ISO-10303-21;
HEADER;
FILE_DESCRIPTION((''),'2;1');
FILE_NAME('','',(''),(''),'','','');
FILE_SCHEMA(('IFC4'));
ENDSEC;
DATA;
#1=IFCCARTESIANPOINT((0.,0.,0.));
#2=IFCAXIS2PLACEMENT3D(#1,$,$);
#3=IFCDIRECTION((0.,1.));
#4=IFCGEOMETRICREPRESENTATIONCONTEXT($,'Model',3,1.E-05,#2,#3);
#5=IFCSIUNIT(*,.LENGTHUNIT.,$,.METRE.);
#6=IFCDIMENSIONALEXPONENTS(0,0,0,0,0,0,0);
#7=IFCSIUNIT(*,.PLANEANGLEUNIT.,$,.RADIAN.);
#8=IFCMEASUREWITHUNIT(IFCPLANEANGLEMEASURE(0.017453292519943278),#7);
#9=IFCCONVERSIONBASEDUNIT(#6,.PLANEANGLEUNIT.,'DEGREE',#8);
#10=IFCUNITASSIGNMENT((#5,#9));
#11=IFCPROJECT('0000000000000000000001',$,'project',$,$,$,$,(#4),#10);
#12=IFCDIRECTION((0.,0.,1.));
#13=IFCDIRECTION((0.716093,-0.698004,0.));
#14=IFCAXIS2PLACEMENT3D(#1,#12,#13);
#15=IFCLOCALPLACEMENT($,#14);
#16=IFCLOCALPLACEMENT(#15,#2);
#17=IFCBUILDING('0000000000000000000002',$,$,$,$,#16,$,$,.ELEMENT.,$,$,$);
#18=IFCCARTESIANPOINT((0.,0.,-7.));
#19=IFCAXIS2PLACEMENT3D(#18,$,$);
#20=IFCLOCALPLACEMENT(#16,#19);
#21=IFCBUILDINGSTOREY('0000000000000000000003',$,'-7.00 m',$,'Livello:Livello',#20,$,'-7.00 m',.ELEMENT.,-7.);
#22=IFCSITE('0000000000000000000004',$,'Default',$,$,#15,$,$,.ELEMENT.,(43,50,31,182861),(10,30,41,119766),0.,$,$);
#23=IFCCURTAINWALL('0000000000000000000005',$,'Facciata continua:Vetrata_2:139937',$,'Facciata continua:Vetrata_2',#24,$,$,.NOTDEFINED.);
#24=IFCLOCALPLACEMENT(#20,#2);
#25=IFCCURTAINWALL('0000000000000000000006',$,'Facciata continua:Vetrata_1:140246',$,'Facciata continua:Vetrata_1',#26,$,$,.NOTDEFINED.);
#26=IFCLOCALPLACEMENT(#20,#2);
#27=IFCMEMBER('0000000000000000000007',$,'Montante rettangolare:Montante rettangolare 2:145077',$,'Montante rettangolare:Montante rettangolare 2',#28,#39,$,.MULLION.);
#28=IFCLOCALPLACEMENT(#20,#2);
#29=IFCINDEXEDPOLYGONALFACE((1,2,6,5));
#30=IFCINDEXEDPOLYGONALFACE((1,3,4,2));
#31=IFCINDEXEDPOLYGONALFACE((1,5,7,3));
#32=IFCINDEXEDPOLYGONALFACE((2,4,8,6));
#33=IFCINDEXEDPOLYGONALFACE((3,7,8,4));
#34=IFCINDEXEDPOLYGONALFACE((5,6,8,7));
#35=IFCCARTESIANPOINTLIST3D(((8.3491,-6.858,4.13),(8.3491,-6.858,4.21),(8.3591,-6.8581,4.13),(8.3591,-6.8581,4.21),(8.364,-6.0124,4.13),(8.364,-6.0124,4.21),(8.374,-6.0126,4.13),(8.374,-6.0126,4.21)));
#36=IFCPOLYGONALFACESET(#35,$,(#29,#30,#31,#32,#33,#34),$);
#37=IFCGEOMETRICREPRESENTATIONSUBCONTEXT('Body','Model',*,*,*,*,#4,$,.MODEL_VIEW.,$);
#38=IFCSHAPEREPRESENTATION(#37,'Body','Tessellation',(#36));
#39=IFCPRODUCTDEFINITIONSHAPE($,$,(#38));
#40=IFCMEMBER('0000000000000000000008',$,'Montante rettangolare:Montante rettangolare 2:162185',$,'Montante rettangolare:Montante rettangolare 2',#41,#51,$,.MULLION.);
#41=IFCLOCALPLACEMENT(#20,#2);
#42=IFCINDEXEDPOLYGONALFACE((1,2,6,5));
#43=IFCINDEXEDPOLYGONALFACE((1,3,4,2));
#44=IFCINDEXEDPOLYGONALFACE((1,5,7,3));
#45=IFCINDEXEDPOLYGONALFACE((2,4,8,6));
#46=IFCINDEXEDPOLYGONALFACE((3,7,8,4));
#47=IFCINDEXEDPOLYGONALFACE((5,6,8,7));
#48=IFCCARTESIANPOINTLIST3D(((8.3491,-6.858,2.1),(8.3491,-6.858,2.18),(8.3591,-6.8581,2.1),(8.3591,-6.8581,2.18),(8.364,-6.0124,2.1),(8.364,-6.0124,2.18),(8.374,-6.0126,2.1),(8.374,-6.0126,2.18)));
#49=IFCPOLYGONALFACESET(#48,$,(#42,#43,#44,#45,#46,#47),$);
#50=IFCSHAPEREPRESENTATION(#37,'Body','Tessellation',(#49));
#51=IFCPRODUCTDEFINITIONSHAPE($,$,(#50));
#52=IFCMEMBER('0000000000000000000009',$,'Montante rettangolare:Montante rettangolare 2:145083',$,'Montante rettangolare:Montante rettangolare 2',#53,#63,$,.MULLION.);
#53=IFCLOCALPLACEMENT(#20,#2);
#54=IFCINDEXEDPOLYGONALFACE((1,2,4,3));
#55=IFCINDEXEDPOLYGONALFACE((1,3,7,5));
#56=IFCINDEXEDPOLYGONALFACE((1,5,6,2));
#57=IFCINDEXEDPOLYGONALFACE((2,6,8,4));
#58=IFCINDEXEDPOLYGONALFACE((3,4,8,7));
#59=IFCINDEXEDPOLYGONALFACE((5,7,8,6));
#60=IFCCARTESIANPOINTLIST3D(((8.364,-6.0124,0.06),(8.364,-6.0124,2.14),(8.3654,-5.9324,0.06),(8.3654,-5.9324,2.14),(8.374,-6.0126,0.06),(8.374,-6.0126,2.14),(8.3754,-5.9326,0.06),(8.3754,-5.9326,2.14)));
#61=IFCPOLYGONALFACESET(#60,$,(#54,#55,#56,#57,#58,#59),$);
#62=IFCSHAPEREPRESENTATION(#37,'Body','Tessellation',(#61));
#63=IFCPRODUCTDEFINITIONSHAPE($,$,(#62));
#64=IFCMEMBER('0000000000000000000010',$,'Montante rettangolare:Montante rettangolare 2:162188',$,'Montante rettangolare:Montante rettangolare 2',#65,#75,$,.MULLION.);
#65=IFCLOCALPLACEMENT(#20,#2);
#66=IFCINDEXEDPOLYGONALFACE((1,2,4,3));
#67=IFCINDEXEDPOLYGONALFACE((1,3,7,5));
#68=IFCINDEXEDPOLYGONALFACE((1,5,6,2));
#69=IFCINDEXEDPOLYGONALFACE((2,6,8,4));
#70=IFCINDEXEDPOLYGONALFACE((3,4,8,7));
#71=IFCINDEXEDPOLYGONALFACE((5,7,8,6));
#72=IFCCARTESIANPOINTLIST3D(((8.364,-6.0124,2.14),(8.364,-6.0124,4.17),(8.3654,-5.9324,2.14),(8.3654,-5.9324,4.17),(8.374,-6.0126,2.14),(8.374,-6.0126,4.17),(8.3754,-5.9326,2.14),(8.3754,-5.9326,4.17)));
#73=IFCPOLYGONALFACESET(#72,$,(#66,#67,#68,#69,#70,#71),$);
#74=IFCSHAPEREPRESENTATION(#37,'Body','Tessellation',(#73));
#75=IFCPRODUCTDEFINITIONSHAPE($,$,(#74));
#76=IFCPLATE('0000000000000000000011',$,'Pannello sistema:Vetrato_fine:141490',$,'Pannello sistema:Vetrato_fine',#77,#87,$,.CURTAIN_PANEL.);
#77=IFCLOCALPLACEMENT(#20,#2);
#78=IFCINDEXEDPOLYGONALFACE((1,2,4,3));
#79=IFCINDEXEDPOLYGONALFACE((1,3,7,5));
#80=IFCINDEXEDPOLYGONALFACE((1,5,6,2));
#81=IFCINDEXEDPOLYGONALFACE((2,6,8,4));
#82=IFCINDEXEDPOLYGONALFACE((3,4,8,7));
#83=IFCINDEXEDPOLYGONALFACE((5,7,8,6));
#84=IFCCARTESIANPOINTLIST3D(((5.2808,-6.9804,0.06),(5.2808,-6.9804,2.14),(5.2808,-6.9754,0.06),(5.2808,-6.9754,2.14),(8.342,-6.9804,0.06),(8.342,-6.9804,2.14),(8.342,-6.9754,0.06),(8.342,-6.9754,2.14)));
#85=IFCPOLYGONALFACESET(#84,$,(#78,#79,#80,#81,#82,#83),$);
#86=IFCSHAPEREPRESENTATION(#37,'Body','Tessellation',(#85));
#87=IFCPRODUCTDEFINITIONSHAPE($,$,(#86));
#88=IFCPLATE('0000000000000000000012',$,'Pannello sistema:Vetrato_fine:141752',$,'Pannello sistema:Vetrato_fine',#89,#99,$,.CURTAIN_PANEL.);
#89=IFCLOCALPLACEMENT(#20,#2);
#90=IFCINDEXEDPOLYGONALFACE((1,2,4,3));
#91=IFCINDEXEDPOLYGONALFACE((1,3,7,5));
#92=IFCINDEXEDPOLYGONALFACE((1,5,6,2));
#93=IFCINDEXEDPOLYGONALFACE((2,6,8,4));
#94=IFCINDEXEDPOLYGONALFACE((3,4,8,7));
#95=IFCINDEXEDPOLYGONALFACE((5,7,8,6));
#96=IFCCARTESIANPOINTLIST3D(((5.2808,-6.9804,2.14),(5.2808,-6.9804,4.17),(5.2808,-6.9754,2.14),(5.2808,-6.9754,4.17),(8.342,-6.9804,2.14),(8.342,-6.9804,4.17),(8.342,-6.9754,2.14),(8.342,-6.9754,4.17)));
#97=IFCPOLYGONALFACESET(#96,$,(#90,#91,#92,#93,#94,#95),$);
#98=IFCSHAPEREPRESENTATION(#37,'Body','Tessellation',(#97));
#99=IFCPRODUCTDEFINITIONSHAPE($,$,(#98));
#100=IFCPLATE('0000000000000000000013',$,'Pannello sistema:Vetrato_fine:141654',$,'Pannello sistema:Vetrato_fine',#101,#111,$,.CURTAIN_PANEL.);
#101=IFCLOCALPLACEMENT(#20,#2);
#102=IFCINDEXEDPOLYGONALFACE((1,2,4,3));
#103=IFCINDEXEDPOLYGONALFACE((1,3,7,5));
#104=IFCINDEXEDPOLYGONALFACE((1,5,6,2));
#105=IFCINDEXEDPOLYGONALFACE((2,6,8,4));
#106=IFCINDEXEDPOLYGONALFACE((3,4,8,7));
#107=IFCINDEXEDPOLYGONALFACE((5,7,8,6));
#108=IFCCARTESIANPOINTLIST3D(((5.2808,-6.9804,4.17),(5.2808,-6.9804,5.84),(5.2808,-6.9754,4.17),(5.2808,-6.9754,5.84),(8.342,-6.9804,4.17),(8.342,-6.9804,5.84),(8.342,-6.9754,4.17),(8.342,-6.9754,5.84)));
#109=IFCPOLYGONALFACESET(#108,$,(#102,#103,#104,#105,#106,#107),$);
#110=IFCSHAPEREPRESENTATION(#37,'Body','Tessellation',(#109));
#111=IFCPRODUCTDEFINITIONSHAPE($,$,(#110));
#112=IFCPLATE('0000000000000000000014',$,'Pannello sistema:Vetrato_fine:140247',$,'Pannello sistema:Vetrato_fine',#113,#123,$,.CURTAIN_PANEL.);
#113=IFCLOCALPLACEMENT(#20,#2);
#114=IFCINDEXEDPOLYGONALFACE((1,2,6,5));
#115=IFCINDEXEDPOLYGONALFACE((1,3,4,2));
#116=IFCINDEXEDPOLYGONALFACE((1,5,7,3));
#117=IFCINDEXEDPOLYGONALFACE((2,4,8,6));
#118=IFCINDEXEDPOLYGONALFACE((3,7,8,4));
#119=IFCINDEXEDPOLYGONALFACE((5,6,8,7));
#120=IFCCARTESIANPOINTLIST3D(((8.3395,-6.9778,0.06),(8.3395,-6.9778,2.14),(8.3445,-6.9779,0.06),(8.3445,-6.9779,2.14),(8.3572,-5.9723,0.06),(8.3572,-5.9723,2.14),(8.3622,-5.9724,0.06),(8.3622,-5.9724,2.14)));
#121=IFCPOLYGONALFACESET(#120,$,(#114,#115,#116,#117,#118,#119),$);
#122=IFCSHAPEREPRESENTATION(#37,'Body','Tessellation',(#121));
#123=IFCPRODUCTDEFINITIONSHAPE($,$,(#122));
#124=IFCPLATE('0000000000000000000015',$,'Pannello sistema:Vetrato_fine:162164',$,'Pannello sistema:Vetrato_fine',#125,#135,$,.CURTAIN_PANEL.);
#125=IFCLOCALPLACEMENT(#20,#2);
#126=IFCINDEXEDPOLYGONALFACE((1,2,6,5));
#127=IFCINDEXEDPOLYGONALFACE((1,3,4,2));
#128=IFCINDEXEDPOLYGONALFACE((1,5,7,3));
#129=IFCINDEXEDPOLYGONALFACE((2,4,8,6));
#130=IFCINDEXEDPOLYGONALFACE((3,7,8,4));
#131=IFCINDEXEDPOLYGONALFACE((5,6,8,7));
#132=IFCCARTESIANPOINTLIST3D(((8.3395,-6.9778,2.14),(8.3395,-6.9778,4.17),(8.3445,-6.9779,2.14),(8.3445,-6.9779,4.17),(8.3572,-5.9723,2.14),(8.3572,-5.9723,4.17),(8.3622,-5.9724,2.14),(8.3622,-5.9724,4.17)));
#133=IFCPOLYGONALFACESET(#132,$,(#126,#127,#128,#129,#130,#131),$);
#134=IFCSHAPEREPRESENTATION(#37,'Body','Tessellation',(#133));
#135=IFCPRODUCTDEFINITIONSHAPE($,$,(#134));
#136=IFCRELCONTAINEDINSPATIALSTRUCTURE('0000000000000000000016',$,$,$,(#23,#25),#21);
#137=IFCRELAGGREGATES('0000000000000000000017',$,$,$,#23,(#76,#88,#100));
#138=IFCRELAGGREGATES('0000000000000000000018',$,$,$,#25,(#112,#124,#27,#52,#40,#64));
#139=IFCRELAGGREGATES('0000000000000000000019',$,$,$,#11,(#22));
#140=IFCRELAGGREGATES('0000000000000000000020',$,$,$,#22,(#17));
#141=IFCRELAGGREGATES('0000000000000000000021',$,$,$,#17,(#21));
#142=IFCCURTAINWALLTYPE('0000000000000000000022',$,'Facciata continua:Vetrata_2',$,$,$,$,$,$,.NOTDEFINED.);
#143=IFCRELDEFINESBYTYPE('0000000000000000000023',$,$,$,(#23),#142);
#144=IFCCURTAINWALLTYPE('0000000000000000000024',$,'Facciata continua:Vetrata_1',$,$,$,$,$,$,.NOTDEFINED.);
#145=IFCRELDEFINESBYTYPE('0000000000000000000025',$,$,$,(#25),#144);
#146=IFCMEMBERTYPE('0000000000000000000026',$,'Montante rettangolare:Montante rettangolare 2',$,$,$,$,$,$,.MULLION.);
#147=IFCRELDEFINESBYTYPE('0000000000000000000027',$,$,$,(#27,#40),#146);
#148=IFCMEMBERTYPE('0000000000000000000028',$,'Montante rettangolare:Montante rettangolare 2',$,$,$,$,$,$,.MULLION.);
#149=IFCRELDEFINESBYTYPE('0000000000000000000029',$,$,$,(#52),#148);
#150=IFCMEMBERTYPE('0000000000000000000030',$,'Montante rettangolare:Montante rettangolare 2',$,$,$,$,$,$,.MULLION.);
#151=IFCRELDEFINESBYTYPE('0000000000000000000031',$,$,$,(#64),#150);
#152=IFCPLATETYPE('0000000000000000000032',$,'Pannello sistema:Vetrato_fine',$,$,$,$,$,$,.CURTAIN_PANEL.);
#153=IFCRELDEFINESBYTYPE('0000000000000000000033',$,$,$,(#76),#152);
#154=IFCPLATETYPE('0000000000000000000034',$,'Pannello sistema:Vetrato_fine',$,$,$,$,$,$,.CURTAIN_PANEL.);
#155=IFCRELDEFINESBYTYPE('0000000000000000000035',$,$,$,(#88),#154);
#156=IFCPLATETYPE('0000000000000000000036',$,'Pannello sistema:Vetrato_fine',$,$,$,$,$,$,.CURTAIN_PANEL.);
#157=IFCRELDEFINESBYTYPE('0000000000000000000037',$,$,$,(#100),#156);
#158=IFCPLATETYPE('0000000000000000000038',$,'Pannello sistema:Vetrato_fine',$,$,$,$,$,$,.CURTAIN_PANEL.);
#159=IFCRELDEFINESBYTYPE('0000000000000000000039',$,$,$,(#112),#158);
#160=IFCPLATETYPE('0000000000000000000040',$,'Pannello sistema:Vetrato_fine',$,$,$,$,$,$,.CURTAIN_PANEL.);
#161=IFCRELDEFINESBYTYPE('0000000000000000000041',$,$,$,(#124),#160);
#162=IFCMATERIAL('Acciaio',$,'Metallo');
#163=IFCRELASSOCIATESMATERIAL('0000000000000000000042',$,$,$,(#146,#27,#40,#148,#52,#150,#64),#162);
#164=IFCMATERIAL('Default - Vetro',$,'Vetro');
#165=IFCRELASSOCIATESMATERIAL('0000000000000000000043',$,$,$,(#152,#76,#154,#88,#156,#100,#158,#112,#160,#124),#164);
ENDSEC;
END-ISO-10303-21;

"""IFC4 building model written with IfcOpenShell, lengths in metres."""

from ifc_helpers import new_model, entity, si_unit, converted_unit, direction, frame, origin, place, context, subcontext, project, spatial, indexed_curve, outline, extrude, source, transform, mapped, material, type_object, type_shapes, element, aggregate, save


model = new_model("IFC4")

# Units and contexts
model_context = context("Model", 3, precision=1e-05, world=origin(), true_north=direction((0.0, 1.0)))
body_context = subcontext(model_context, "Body", "Model", "MODEL_VIEW")
ifc_project = project(units=[si_unit("LENGTHUNIT", "METRE"), converted_unit("PLANEANGLEUNIT", "DEGREE", entity("IfcPlaneAngleMeasure", 0.017453292519943278), si_unit("PLANEANGLEUNIT", "RADIAN"), dimensions=[0, 0, 0, 0, 0, 0, 0])], contexts=[model_context])

# Site, building, storey
site_placement = place(None, frame((0.0, 0.0, 0.0), z_axis=(0.0, 0.0, 1.0), x_axis=(0.716093, -0.698004, 0.0)))
site = spatial("IfcSite", under=ifc_project, at=site_placement, Name="Default", CompositionType="ELEMENT", RefLatitude=(43, 50, 31, 182861), RefLongitude=(10, 30, 41, 119766), RefElevation=0.0)
building_placement = place(site_placement, origin())
building = spatial("IfcBuilding", under=site, at=building_placement, CompositionType="ELEMENT")
storey_placement = place(building_placement, frame((0.0, 0.0, -7.0)))
storey = spatial("IfcBuildingStorey", under=building, at=storey_placement, Name="-7.00 m", ObjectType="Livello:Livello", LongName="-7.00 m", CompositionType="ELEMENT", Elevation=-7.0)

# Curtain walls
curtain_wall_type_1 = type_object("IfcCurtainWallType", Name="Facciata continua:Vetrata_2", PredefinedType="NOTDEFINED")
curtain_wall_1_placement = place(storey_placement, frame((0.0, 0.0, 7.0)))
curtain_wall_1 = element("IfcCurtainWall", 1, at=curtain_wall_1_placement, inside=storey, type_object=curtain_wall_type_1, Name="Facciata continua:Vetrata_2:139937", ObjectType="Facciata continua:Vetrata_2", PredefinedType="NOTDEFINED")
ifc_material_1 = material(Name="Acciaio", Category="Metallo")
curtain_wall_type_2 = type_object("IfcCurtainWallType", Name="Facciata continua:Vetrata_1", PredefinedType="NOTDEFINED")
curtain_wall_2_placement = place(storey_placement, frame((0.0, 0.0, 7.0)))
curtain_wall_2 = element("IfcCurtainWall", 2, at=curtain_wall_2_placement, inside=storey, type_object=curtain_wall_type_2, Name="Facciata continua:Vetrata_1:140246", ObjectType="Facciata continua:Vetrata_1", PredefinedType="NOTDEFINED")

# Members
member_type_1 = type_object("IfcMemberType", Name="Montante rettangolare:Montante rettangolare 2", PredefinedType="MULLION", material=ifc_material_1)
shared_shape_1 = source(origin(), body_context, "Body", "SweptSolid", [
    extrude(outline(indexed_curve([(-0.04, -0.005), (0.04, -0.005), (0.04, 0.005), (-0.04, 0.005), (-0.04, -0.005)], self_intersect=False)), frame((0.0, 0.01, -0.8457), z_axis=(0.0, 0.0, 1.0), x_axis=(-1.0, 0.0, 0.0)), (0.0, 0.0, 1.0), 0.8457),
])
type_shapes(member_type_1, [shared_shape_1])
member_1_placement = place(curtain_wall_2_placement, frame((8.359, -6.0123, -2.83), z_axis=(0.017636, 0.999844, 0.0), x_axis=(0.0, 0.0, 1.0)))
member_1 = element("IfcMember", 3, at=member_1_placement, type_object=member_type_1, material=ifc_material_1, Name="Montante rettangolare:Montante rettangolare 2:145077", ObjectType="Montante rettangolare:Montante rettangolare 2", PredefinedType="MULLION", context=body_context, shape_type="MappedRepresentation", body=[
    mapped(shared_shape_1, transform((0.0, 0.0, 0.0), scale=1.0)),
])
member_2_placement = place(curtain_wall_2_placement, frame((8.359, -6.0123, -4.86), z_axis=(0.017636, 0.999844, 0.0), x_axis=(0.0, 0.0, 1.0)))
member_2 = element("IfcMember", 4, at=member_2_placement, type_object=member_type_1, material=ifc_material_1, Name="Montante rettangolare:Montante rettangolare 2:162185", ObjectType="Montante rettangolare:Montante rettangolare 2", PredefinedType="MULLION", context=body_context, shape_type="MappedRepresentation", body=[
    mapped(shared_shape_1, transform((0.0, 0.0, 0.0), scale=1.0)),
])
member_type_2 = type_object("IfcMemberType", Name="Montante rettangolare:Montante rettangolare 2", PredefinedType="MULLION", material=ifc_material_1)
shared_shape_2 = source(origin(), body_context, "Body", "SweptSolid", [
    extrude(outline(indexed_curve([(-0.04, -0.005), (0.04, -0.005), (0.04, 0.005), (-0.04, 0.005), (-0.04, -0.005)], self_intersect=False)), frame((0.0, 0.01, -2.08), z_axis=(0.0, 0.0, 1.0), x_axis=(-1.0, 0.0, 0.0)), (0.0, 0.0, 1.0), 2.08),
])
type_shapes(member_type_2, [shared_shape_2])
member_3_placement = place(curtain_wall_2_placement, frame((8.3597, -5.9723, -6.94), z_axis=(0.0, 0.0, -1.0), x_axis=(0.017636, 0.999844, 0.0)))
member_3 = element("IfcMember", 5, at=member_3_placement, type_object=member_type_2, material=ifc_material_1, Name="Montante rettangolare:Montante rettangolare 2:145083", ObjectType="Montante rettangolare:Montante rettangolare 2", PredefinedType="MULLION", context=body_context, shape_type="MappedRepresentation", body=[
    mapped(shared_shape_2, transform((0.0, 0.0, 0.0), scale=1.0)),
])
member_type_3 = type_object("IfcMemberType", Name="Montante rettangolare:Montante rettangolare 2", PredefinedType="MULLION", material=ifc_material_1)
shared_shape_3 = source(origin(), body_context, "Body", "SweptSolid", [
    extrude(outline(indexed_curve([(-0.04, -0.005), (0.04, -0.005), (0.04, 0.005), (-0.04, 0.005), (-0.04, -0.005)], self_intersect=False)), frame((0.0, 0.01, -2.03), z_axis=(0.0, 0.0, 1.0), x_axis=(-1.0, 0.0, 0.0)), (0.0, 0.0, 1.0), 2.03),
])
type_shapes(member_type_3, [shared_shape_3])
member_4_placement = place(curtain_wall_2_placement, frame((8.3597, -5.9723, -4.86), z_axis=(0.0, 0.0, -1.0), x_axis=(0.017636, 0.999844, 0.0)))
member_4 = element("IfcMember", 6, at=member_4_placement, type_object=member_type_3, material=ifc_material_1, Name="Montante rettangolare:Montante rettangolare 2:162188", ObjectType="Montante rettangolare:Montante rettangolare 2", PredefinedType="MULLION", context=body_context, shape_type="MappedRepresentation", body=[
    mapped(shared_shape_3, transform((0.0, 0.0, 0.0), scale=1.0)),
])

# Plates
ifc_material_2 = material(Name="Default - Vetro", Category="Vetro")
plate_type_1 = type_object("IfcPlateType", Name="Pannello sistema:Vetrato_fine", PredefinedType="CURTAIN_PANEL", material=ifc_material_2)
shared_shape_4 = source(origin(), body_context, "Body", "SweptSolid", [
    extrude(outline(indexed_curve([(-0.0025, -1.5306), (0.0025, -1.5306), (0.0025, 1.5306), (-0.0025, 1.5306), (-0.0025, -1.5306)], self_intersect=False)), frame((0.0, 0.0, 0.0), z_axis=(0.0, 0.0, 1.0), x_axis=(0.0, 1.0, 0.0)), (0.0, 0.0, 1.0), 2.08),
])
type_shapes(plate_type_1, [shared_shape_4])
plate_1_placement = place(curtain_wall_1_placement, frame((6.8114, -6.9779, -6.94)))
plate_1 = element("IfcPlate", 7, at=plate_1_placement, type_object=plate_type_1, material=ifc_material_2, Name="Pannello sistema:Vetrato_fine:141490", ObjectType="Pannello sistema:Vetrato_fine", PredefinedType="CURTAIN_PANEL", context=body_context, shape_type="MappedRepresentation", body=[
    mapped(shared_shape_4, transform((0.0, 0.0, 0.0), scale=1.0)),
])
plate_type_2 = type_object("IfcPlateType", Name="Pannello sistema:Vetrato_fine", PredefinedType="CURTAIN_PANEL", material=ifc_material_2)
shared_shape_5 = source(origin(), body_context, "Body", "SweptSolid", [
    extrude(outline(indexed_curve([(-0.0025, -1.5306), (0.0025, -1.5306), (0.0025, 1.5306), (-0.0025, 1.5306), (-0.0025, -1.5306)], self_intersect=False)), frame((0.0, 0.0, 0.0), z_axis=(0.0, 0.0, 1.0), x_axis=(0.0, 1.0, 0.0)), (0.0, 0.0, 1.0), 2.03),
])
type_shapes(plate_type_2, [shared_shape_5])
plate_2_placement = place(curtain_wall_1_placement, frame((6.8114, -6.9779, -4.86)))
plate_2 = element("IfcPlate", 8, at=plate_2_placement, type_object=plate_type_2, material=ifc_material_2, Name="Pannello sistema:Vetrato_fine:141752", ObjectType="Pannello sistema:Vetrato_fine", PredefinedType="CURTAIN_PANEL", context=body_context, shape_type="MappedRepresentation", body=[
    mapped(shared_shape_5, transform((0.0, 0.0, 0.0), scale=1.0)),
])
plate_type_3 = type_object("IfcPlateType", Name="Pannello sistema:Vetrato_fine", PredefinedType="CURTAIN_PANEL", material=ifc_material_2)
shared_shape_6 = source(origin(), body_context, "Body", "SweptSolid", [
    extrude(outline(indexed_curve([(-0.0025, -1.5306), (0.0025, -1.5306), (0.0025, 1.5306), (-0.0025, 1.5306), (-0.0025, -1.5306)], self_intersect=False)), frame((0.0, 0.0, 0.0), z_axis=(0.0, 0.0, 1.0), x_axis=(0.0, 1.0, 0.0)), (0.0, 0.0, 1.0), 1.67),
])
type_shapes(plate_type_3, [shared_shape_6])
plate_3_placement = place(curtain_wall_1_placement, frame((6.8114, -6.9779, -2.83)))
plate_3 = element("IfcPlate", 9, at=plate_3_placement, type_object=plate_type_3, material=ifc_material_2, Name="Pannello sistema:Vetrato_fine:141654", ObjectType="Pannello sistema:Vetrato_fine", PredefinedType="CURTAIN_PANEL", context=body_context, shape_type="MappedRepresentation", body=[
    mapped(shared_shape_6, transform((0.0, 0.0, 0.0), scale=1.0)),
])
aggregate(curtain_wall_1, [plate_1, plate_2, plate_3])
plate_type_4 = type_object("IfcPlateType", Name="Pannello sistema:Vetrato_fine", PredefinedType="CURTAIN_PANEL", material=ifc_material_2)
shared_shape_7 = source(origin(), body_context, "Body", "SweptSolid", [
    extrude(outline(indexed_curve([(-0.0025, -0.5028), (0.0025, -0.5028), (0.0025, 0.5028), (-0.0025, 0.5028), (-0.0025, -0.5028)], self_intersect=False)), frame((0.0, 0.0, 0.0), z_axis=(0.0, 0.0, 1.0), x_axis=(0.0, 1.0, 0.0)), (0.0, 0.0, 1.0), 2.08),
])
type_shapes(plate_type_4, [shared_shape_7])
plate_4_placement = place(curtain_wall_2_placement, frame((8.3508, -6.4751, -6.94), z_axis=(0.0, 0.0, 1.0), x_axis=(0.017636, 0.999844, 0.0)))
plate_4 = element("IfcPlate", 10, at=plate_4_placement, type_object=plate_type_4, material=ifc_material_2, Name="Pannello sistema:Vetrato_fine:140247", ObjectType="Pannello sistema:Vetrato_fine", PredefinedType="CURTAIN_PANEL", context=body_context, shape_type="MappedRepresentation", body=[
    mapped(shared_shape_7, transform((0.0, 0.0, 0.0), scale=1.0)),
])
plate_type_5 = type_object("IfcPlateType", Name="Pannello sistema:Vetrato_fine", PredefinedType="CURTAIN_PANEL", material=ifc_material_2)
shared_shape_8 = source(origin(), body_context, "Body", "SweptSolid", [
    extrude(outline(indexed_curve([(-0.0025, -0.5028), (0.0025, -0.5028), (0.0025, 0.5028), (-0.0025, 0.5028), (-0.0025, -0.5028)], self_intersect=False)), frame((0.0, 0.0, 0.0), z_axis=(0.0, 0.0, 1.0), x_axis=(0.0, 1.0, 0.0)), (0.0, 0.0, 1.0), 2.03),
])
type_shapes(plate_type_5, [shared_shape_8])
plate_5_placement = place(curtain_wall_2_placement, frame((8.3508, -6.4751, -4.86), z_axis=(0.0, 0.0, 1.0), x_axis=(0.017636, 0.999844, 0.0)))
plate_5 = element("IfcPlate", 11, at=plate_5_placement, type_object=plate_type_5, material=ifc_material_2, Name="Pannello sistema:Vetrato_fine:162164", ObjectType="Pannello sistema:Vetrato_fine", PredefinedType="CURTAIN_PANEL", context=body_context, shape_type="MappedRepresentation", body=[
    mapped(shared_shape_8, transform((0.0, 0.0, 0.0), scale=1.0)),
])

aggregate(curtain_wall_2, [plate_4, plate_5, member_1, member_3, member_2, member_4])

save(model, "model.ifc")
